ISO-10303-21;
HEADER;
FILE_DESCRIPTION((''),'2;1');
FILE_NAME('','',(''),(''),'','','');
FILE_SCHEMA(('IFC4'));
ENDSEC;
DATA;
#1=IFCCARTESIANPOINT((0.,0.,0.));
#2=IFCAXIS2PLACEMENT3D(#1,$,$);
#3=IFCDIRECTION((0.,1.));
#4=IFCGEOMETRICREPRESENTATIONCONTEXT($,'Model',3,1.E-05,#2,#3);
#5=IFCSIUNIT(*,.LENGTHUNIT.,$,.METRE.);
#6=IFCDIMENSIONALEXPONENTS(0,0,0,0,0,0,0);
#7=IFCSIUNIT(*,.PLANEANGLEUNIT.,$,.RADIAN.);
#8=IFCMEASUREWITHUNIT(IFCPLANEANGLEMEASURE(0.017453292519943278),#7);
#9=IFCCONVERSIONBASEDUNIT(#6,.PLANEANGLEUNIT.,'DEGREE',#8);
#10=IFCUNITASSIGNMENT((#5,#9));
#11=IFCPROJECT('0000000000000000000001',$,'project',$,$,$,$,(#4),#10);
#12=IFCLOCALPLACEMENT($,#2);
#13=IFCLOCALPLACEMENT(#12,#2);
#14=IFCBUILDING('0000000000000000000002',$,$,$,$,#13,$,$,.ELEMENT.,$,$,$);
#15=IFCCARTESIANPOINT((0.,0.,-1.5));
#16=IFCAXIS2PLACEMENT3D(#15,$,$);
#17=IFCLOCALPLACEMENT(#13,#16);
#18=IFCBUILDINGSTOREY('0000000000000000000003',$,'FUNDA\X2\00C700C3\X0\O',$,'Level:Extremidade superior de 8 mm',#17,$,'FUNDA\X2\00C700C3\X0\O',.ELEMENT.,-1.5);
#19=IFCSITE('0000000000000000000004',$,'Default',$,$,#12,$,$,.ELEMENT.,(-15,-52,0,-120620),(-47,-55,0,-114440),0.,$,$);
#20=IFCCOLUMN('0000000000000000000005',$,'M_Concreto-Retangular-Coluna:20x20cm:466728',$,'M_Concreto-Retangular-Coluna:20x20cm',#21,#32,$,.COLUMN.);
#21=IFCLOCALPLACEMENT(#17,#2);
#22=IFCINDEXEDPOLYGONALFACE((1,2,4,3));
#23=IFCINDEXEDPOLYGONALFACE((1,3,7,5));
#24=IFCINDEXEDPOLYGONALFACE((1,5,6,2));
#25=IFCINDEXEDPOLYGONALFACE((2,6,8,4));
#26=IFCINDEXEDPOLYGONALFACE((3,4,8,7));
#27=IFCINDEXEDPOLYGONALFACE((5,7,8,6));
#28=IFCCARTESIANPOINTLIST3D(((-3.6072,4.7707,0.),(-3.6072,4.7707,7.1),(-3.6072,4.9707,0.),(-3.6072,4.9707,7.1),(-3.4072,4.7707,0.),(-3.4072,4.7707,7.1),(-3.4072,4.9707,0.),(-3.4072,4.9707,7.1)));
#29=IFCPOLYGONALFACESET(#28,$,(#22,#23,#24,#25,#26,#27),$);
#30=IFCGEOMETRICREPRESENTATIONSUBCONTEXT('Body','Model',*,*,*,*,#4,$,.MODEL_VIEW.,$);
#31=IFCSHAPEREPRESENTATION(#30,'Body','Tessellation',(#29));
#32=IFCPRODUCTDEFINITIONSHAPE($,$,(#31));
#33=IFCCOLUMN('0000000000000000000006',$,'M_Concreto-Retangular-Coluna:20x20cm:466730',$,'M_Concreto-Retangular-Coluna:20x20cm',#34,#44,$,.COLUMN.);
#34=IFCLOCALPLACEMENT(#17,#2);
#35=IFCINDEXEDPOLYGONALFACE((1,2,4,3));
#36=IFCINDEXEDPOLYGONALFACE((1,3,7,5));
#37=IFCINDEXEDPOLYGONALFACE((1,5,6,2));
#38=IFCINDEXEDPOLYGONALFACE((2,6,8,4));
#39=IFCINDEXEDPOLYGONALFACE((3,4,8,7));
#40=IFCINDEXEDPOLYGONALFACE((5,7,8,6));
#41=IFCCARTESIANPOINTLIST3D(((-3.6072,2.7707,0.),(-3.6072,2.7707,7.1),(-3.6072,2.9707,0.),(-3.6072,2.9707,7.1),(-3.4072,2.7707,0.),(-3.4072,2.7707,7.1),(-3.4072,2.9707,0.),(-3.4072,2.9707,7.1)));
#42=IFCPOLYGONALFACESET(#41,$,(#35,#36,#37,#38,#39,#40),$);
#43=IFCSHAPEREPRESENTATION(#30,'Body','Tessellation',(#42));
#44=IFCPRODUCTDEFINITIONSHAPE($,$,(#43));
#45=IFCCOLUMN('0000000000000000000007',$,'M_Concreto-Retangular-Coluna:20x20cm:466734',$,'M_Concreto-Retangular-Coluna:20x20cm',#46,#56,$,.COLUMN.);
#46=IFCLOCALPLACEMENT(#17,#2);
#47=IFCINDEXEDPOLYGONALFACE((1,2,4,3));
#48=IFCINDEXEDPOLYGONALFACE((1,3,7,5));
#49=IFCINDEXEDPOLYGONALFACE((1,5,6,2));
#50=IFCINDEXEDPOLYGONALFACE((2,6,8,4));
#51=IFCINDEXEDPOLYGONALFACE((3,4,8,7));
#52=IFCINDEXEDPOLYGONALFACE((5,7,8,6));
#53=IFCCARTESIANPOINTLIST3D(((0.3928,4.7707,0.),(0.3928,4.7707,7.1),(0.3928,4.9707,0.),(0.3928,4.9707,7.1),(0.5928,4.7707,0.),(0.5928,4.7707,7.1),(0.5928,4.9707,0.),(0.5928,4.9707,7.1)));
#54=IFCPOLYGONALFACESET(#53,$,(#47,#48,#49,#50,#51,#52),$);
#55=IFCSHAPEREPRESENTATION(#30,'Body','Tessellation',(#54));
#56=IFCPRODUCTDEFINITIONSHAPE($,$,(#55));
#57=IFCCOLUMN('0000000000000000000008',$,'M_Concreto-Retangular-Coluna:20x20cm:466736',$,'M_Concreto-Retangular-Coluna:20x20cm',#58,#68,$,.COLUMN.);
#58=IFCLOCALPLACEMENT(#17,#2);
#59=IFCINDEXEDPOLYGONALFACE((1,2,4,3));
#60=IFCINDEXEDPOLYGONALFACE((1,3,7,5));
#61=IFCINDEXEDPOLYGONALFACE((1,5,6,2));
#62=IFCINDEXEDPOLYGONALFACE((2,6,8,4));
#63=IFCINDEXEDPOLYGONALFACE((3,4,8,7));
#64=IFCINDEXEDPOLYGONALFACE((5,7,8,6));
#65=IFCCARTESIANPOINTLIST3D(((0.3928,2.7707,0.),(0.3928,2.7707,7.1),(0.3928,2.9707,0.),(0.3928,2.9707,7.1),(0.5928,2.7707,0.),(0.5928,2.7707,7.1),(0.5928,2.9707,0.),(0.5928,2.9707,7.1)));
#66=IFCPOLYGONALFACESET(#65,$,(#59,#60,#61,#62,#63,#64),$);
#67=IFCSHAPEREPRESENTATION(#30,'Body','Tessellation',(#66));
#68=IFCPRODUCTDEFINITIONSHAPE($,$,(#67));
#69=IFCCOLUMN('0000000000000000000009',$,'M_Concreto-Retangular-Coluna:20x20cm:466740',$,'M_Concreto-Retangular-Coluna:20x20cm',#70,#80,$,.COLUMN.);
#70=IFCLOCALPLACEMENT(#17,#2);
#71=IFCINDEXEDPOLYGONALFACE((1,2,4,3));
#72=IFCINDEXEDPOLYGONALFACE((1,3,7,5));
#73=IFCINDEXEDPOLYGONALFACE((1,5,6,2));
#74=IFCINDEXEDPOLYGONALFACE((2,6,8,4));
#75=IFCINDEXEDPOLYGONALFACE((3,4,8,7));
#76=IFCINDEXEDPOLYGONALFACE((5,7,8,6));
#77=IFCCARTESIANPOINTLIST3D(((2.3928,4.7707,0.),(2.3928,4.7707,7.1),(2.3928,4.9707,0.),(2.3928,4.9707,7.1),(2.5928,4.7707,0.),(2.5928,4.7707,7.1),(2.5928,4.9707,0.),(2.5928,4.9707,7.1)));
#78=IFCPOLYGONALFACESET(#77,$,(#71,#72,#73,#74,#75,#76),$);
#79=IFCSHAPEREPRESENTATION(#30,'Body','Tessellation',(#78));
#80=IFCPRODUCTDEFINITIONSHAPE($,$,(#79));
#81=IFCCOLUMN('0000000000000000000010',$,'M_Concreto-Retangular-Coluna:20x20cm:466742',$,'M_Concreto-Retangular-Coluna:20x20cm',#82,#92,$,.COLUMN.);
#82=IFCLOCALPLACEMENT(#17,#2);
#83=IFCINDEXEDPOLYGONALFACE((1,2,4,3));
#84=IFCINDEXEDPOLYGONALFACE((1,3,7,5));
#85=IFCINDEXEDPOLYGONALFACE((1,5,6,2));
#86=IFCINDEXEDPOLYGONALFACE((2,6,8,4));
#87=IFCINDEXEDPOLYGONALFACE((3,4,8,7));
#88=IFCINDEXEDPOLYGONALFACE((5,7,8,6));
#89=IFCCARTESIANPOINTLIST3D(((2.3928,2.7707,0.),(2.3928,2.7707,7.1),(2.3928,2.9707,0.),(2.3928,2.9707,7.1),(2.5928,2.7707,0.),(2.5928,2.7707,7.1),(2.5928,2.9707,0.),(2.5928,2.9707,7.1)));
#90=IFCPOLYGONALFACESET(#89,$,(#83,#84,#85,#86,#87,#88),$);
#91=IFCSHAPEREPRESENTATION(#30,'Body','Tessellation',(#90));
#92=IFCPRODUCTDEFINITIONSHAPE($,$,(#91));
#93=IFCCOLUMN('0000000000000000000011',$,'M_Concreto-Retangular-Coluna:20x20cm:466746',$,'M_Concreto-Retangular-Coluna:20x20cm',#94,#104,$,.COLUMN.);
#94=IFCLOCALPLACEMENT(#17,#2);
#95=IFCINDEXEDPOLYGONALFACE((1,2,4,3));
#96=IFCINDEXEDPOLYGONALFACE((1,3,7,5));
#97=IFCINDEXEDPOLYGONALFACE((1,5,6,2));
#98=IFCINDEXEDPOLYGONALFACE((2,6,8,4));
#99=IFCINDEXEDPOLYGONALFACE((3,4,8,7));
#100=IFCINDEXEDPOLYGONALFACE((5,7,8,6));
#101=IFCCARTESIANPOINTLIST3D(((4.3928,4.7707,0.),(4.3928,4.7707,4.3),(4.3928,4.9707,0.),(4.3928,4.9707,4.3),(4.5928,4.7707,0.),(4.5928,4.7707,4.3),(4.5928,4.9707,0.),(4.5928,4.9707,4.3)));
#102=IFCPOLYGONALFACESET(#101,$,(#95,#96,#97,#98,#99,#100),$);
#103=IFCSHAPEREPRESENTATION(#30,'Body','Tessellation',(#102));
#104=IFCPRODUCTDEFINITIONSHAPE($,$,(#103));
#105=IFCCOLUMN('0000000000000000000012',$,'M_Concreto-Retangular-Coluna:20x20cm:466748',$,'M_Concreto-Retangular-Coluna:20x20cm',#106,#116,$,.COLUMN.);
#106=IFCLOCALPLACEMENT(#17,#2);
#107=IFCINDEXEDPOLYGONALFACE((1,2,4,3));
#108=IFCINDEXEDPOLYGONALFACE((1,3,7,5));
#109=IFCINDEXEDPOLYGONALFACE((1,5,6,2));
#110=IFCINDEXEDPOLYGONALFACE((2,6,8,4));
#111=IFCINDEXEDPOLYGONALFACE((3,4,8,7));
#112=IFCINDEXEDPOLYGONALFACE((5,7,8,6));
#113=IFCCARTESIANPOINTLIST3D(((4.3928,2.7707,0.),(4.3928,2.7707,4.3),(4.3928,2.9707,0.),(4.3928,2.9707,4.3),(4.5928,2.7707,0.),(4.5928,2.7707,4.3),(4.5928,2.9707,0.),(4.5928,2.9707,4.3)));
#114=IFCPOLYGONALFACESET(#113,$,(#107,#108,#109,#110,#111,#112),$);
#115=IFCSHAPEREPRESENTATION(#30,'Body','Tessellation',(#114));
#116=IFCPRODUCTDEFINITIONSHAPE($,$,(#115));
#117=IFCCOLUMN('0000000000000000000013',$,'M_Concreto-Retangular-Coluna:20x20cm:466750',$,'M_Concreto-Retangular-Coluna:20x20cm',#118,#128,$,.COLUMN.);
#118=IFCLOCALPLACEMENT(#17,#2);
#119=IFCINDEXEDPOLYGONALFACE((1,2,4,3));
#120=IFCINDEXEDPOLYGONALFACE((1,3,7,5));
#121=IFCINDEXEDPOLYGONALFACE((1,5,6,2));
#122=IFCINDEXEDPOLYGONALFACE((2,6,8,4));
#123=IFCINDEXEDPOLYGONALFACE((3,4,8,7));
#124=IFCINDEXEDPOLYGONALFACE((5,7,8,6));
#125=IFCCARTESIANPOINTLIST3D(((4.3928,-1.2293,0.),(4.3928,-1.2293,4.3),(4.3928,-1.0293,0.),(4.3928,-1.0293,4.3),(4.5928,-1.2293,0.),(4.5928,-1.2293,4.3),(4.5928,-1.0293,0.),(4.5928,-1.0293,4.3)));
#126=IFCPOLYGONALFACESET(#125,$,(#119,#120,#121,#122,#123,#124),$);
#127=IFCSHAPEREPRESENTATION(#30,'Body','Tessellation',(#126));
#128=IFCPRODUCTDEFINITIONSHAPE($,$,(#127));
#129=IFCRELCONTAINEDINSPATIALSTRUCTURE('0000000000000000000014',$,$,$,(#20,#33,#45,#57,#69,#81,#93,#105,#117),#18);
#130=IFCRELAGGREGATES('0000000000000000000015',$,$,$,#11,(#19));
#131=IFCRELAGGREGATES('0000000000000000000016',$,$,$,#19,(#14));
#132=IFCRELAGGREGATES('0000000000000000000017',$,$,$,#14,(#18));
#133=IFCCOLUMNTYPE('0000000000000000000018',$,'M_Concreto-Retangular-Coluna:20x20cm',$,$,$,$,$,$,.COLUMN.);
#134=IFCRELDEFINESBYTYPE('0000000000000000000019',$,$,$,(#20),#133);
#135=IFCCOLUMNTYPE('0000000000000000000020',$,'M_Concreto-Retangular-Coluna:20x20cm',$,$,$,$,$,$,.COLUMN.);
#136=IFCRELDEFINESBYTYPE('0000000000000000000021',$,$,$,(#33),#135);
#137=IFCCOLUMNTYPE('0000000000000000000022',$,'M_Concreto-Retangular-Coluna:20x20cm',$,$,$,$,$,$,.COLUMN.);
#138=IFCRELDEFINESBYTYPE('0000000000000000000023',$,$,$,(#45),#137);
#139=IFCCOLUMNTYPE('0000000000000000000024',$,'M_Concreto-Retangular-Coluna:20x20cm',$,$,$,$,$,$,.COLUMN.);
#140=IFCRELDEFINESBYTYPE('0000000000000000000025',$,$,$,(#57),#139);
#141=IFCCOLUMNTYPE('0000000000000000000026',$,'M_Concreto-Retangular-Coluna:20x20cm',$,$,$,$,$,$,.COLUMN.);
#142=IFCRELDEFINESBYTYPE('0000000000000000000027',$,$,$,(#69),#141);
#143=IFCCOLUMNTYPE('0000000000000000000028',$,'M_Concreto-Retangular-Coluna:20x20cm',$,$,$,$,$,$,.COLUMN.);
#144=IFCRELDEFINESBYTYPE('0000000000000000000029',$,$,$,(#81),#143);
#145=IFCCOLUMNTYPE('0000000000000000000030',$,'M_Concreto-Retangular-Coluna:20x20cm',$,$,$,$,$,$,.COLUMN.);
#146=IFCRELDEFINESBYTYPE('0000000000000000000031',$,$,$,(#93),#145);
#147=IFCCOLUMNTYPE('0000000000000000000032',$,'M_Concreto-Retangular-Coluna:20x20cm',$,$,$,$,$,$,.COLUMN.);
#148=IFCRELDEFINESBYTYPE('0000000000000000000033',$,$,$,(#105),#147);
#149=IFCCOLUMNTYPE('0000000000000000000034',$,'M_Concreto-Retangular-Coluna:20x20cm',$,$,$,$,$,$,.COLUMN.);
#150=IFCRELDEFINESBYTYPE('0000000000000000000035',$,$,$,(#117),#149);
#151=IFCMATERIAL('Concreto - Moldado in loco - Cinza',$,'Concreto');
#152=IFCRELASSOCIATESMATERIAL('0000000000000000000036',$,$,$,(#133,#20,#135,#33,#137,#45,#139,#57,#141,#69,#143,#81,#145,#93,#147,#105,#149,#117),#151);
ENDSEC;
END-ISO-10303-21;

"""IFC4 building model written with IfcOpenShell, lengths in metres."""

from ifc_helpers import new_model, entity, si_unit, converted_unit, direction, frame, origin, place, context, subcontext, project, spatial, indexed_curve, outline, extrude, source, transform, mapped, material, type_object, type_shapes, element, save


model = new_model("IFC4")

# Units and contexts
model_context = context("Model", 3, precision=1e-05, world=origin(), true_north=direction((0.0, 1.0)))
body_context = subcontext(model_context, "Body", "Model", "MODEL_VIEW")
ifc_project = project(units=[si_unit("LENGTHUNIT", "METRE"), converted_unit("PLANEANGLEUNIT", "DEGREE", entity("IfcPlaneAngleMeasure", 0.017453292519943278), si_unit("PLANEANGLEUNIT", "RADIAN"), dimensions=[0, 0, 0, 0, 0, 0, 0])], contexts=[model_context])

# Site, building, storey
site_placement = place(None, origin())
site = spatial("IfcSite", under=ifc_project, at=site_placement, Name="Default", CompositionType="ELEMENT", RefLatitude=(-15, -52, 0, -120620), RefLongitude=(-47, -55, 0, -114440), RefElevation=0.0)
building_placement = place(site_placement, origin())
building = spatial("IfcBuilding", under=site, at=building_placement, CompositionType="ELEMENT")
storey_placement = place(building_placement, frame((0.0, 0.0, -1.5)))
storey = spatial("IfcBuildingStorey", under=building, at=storey_placement, Name="FUNDAÇÃO", ObjectType="Level:Extremidade superior de 8 mm", LongName="FUNDAÇÃO", CompositionType="ELEMENT", Elevation=-1.5)

# Columns
ifc_material = material(Name="Concreto - Moldado in loco - Cinza", Category="Concreto")
column_type_1 = type_object("IfcColumnType", Name="M_Concreto-Retangular-Coluna:20x20cm", PredefinedType="COLUMN", material=ifc_material)
shared_shape_1 = source(origin(), body_context, "Body", "SweptSolid", [
    extrude(outline(indexed_curve([(-0.1, -0.1), (0.1, -0.1), (0.1, 0.1), (-0.1, 0.1), (-0.1, -0.1)], self_intersect=False)), frame((-3.5072, 4.8707, -1.5)), (0.0, 0.0, 1.0), 7.1),
])
type_shapes(column_type_1, [shared_shape_1])
column_1_placement = place(storey_placement, frame((0.0, 0.0, 1.5)))
element("IfcColumn", 1, at=column_1_placement, inside=storey, type_object=column_type_1, material=ifc_material, Name="M_Concreto-Retangular-Coluna:20x20cm:466728", ObjectType="M_Concreto-Retangular-Coluna:20x20cm", PredefinedType="COLUMN", context=body_context, shape_type="MappedRepresentation", body=[
    mapped(shared_shape_1, transform((0.0, 0.0, 0.0), scale=1.0)),
])
column_type_2 = type_object("IfcColumnType", Name="M_Concreto-Retangular-Coluna:20x20cm", PredefinedType="COLUMN", material=ifc_material)
shared_shape_2 = source(origin(), body_context, "Body", "SweptSolid", [
    extrude(outline(indexed_curve([(-0.1, -0.1), (0.1, -0.1), (0.1, 0.1), (-0.1, 0.1), (-0.1, -0.1)], self_intersect=False)), frame((-3.5072, 2.8707, -1.5)), (0.0, 0.0, 1.0), 7.1),
])
type_shapes(column_type_2, [shared_shape_2])
column_2_placement = place(storey_placement, frame((0.0, 0.0, 1.5)))
element("IfcColumn", 2, at=column_2_placement, inside=storey, type_object=column_type_2, material=ifc_material, Name="M_Concreto-Retangular-Coluna:20x20cm:466730", ObjectType="M_Concreto-Retangular-Coluna:20x20cm", PredefinedType="COLUMN", context=body_context, shape_type="MappedRepresentation", body=[
    mapped(shared_shape_2, transform((0.0, 0.0, 0.0), scale=1.0)),
])
column_type_3 = type_object("IfcColumnType", Name="M_Concreto-Retangular-Coluna:20x20cm", PredefinedType="COLUMN", material=ifc_material)
shared_shape_3 = source(origin(), body_context, "Body", "SweptSolid", [
    extrude(outline(indexed_curve([(-0.1, -0.1), (0.1, -0.1), (0.1, 0.1), (-0.1, 0.1), (-0.1, -0.1)], self_intersect=False)), frame((0.4928, 4.8707, -1.5)), (0.0, 0.0, 1.0), 7.1),
])
type_shapes(column_type_3, [shared_shape_3])
column_3_placement = place(storey_placement, frame((0.0, 0.0, 1.5)))
element("IfcColumn", 3, at=column_3_placement, inside=storey, type_object=column_type_3, material=ifc_material, Name="M_Concreto-Retangular-Coluna:20x20cm:466734", ObjectType="M_Concreto-Retangular-Coluna:20x20cm", PredefinedType="COLUMN", context=body_context, shape_type="MappedRepresentation", body=[
    mapped(shared_shape_3, transform((0.0, 0.0, 0.0), scale=1.0)),
])
column_type_4 = type_object("IfcColumnType", Name="M_Concreto-Retangular-Coluna:20x20cm", PredefinedType="COLUMN", material=ifc_material)
shared_shape_4 = source(origin(), body_context, "Body", "SweptSolid", [
    extrude(outline(indexed_curve([(-0.1, -0.1), (0.1, -0.1), (0.1, 0.1), (-0.1, 0.1), (-0.1, -0.1)], self_intersect=False)), frame((0.4928, 2.8707, -1.5)), (0.0, 0.0, 1.0), 7.1),
])
type_shapes(column_type_4, [shared_shape_4])
column_4_placement = place(storey_placement, frame((0.0, 0.0, 1.5)))
element("IfcColumn", 4, at=column_4_placement, inside=storey, type_object=column_type_4, material=ifc_material, Name="M_Concreto-Retangular-Coluna:20x20cm:466736", ObjectType="M_Concreto-Retangular-Coluna:20x20cm", PredefinedType="COLUMN", context=body_context, shape_type="MappedRepresentation", body=[
    mapped(shared_shape_4, transform((0.0, 0.0, 0.0), scale=1.0)),
])
column_type_5 = type_object("IfcColumnType", Name="M_Concreto-Retangular-Coluna:20x20cm", PredefinedType="COLUMN", material=ifc_material)
shared_shape_5 = source(origin(), body_context, "Body", "SweptSolid", [
    extrude(outline(indexed_curve([(-0.1, -0.1), (0.1, -0.1), (0.1, 0.1), (-0.1, 0.1), (-0.1, -0.1)], self_intersect=False)), frame((2.4928, 4.8707, -1.5)), (0.0, 0.0, 1.0), 7.1),
])
type_shapes(column_type_5, [shared_shape_5])
column_5_placement = place(storey_placement, frame((0.0, 0.0, 1.5)))
element("IfcColumn", 5, at=column_5_placement, inside=storey, type_object=column_type_5, material=ifc_material, Name="M_Concreto-Retangular-Coluna:20x20cm:466740", ObjectType="M_Concreto-Retangular-Coluna:20x20cm", PredefinedType="COLUMN", context=body_context, shape_type="MappedRepresentation", body=[
    mapped(shared_shape_5, transform((0.0, 0.0, 0.0), scale=1.0)),
])
column_type_6 = type_object("IfcColumnType", Name="M_Concreto-Retangular-Coluna:20x20cm", PredefinedType="COLUMN", material=ifc_material)
shared_shape_6 = source(origin(), body_context, "Body", "SweptSolid", [
    extrude(outline(indexed_curve([(-0.1, -0.1), (0.1, -0.1), (0.1, 0.1), (-0.1, 0.1), (-0.1, -0.1)], self_intersect=False)), frame((2.4928, 2.8707, -1.5)), (0.0, 0.0, 1.0), 7.1),
])
type_shapes(column_type_6, [shared_shape_6])
column_6_placement = place(storey_placement, frame((0.0, 0.0, 1.5)))
element("IfcColumn", 6, at=column_6_placement, inside=storey, type_object=column_type_6, material=ifc_material, Name="M_Concreto-Retangular-Coluna:20x20cm:466742", ObjectType="M_Concreto-Retangular-Coluna:20x20cm", PredefinedType="COLUMN", context=body_context, shape_type="MappedRepresentation", body=[
    mapped(shared_shape_6, transform((0.0, 0.0, 0.0), scale=1.0)),
])
column_type_7 = type_object("IfcColumnType", Name="M_Concreto-Retangular-Coluna:20x20cm", PredefinedType="COLUMN", material=ifc_material)
shared_shape_7 = source(origin(), body_context, "Body", "SweptSolid", [
    extrude(outline(indexed_curve([(-0.1, -0.1), (0.1, -0.1), (0.1, 0.1), (-0.1, 0.1), (-0.1, -0.1)], self_intersect=False)), frame((4.4928, 4.8707, -1.5)), (0.0, 0.0, 1.0), 4.3),
])
type_shapes(column_type_7, [shared_shape_7])
column_7_placement = place(storey_placement, frame((0.0, 0.0, 1.5)))
element("IfcColumn", 7, at=column_7_placement, inside=storey, type_object=column_type_7, material=ifc_material, Name="M_Concreto-Retangular-Coluna:20x20cm:466746", ObjectType="M_Concreto-Retangular-Coluna:20x20cm", PredefinedType="COLUMN", context=body_context, shape_type="MappedRepresentation", body=[
    mapped(shared_shape_7, transform((0.0, 0.0, 0.0), scale=1.0)),
])
column_type_8 = type_object("IfcColumnType", Name="M_Concreto-Retangular-Coluna:20x20cm", PredefinedType="COLUMN", material=ifc_material)
shared_shape_8 = source(origin(), body_context, "Body", "SweptSolid", [
    extrude(outline(indexed_curve([(-0.1, -0.1), (0.1, -0.1), (0.1, 0.1), (-0.1, 0.1), (-0.1, -0.1)], self_intersect=False)), frame((4.4928, 2.8707, -1.5)), (0.0, 0.0, 1.0), 4.3),
])
type_shapes(column_type_8, [shared_shape_8])
column_8_placement = place(storey_placement, frame((0.0, 0.0, 1.5)))
element("IfcColumn", 8, at=column_8_placement, inside=storey, type_object=column_type_8, material=ifc_material, Name="M_Concreto-Retangular-Coluna:20x20cm:466748", ObjectType="M_Concreto-Retangular-Coluna:20x20cm", PredefinedType="COLUMN", context=body_context, shape_type="MappedRepresentation", body=[
    mapped(shared_shape_8, transform((0.0, 0.0, 0.0), scale=1.0)),
])
column_type_9 = type_object("IfcColumnType", Name="M_Concreto-Retangular-Coluna:20x20cm", PredefinedType="COLUMN", material=ifc_material)
shared_shape_9 = source(origin(), body_context, "Body", "SweptSolid", [
    extrude(outline(indexed_curve([(-0.1, -0.1), (0.1, -0.1), (0.1, 0.1), (-0.1, 0.1), (-0.1, -0.1)], self_intersect=False)), frame((4.4928, -1.1293, -1.5)), (0.0, 0.0, 1.0), 4.3),
])
type_shapes(column_type_9, [shared_shape_9])
column_9_placement = place(storey_placement, frame((0.0, 0.0, 1.5)))
element("IfcColumn", 9, at=column_9_placement, inside=storey, type_object=column_type_9, material=ifc_material, Name="M_Concreto-Retangular-Coluna:20x20cm:466750", ObjectType="M_Concreto-Retangular-Coluna:20x20cm", PredefinedType="COLUMN", context=body_context, shape_type="MappedRepresentation", body=[
    mapped(shared_shape_9, transform((0.0, 0.0, 0.0), scale=1.0)),
])

save(model, "model.ifc")
